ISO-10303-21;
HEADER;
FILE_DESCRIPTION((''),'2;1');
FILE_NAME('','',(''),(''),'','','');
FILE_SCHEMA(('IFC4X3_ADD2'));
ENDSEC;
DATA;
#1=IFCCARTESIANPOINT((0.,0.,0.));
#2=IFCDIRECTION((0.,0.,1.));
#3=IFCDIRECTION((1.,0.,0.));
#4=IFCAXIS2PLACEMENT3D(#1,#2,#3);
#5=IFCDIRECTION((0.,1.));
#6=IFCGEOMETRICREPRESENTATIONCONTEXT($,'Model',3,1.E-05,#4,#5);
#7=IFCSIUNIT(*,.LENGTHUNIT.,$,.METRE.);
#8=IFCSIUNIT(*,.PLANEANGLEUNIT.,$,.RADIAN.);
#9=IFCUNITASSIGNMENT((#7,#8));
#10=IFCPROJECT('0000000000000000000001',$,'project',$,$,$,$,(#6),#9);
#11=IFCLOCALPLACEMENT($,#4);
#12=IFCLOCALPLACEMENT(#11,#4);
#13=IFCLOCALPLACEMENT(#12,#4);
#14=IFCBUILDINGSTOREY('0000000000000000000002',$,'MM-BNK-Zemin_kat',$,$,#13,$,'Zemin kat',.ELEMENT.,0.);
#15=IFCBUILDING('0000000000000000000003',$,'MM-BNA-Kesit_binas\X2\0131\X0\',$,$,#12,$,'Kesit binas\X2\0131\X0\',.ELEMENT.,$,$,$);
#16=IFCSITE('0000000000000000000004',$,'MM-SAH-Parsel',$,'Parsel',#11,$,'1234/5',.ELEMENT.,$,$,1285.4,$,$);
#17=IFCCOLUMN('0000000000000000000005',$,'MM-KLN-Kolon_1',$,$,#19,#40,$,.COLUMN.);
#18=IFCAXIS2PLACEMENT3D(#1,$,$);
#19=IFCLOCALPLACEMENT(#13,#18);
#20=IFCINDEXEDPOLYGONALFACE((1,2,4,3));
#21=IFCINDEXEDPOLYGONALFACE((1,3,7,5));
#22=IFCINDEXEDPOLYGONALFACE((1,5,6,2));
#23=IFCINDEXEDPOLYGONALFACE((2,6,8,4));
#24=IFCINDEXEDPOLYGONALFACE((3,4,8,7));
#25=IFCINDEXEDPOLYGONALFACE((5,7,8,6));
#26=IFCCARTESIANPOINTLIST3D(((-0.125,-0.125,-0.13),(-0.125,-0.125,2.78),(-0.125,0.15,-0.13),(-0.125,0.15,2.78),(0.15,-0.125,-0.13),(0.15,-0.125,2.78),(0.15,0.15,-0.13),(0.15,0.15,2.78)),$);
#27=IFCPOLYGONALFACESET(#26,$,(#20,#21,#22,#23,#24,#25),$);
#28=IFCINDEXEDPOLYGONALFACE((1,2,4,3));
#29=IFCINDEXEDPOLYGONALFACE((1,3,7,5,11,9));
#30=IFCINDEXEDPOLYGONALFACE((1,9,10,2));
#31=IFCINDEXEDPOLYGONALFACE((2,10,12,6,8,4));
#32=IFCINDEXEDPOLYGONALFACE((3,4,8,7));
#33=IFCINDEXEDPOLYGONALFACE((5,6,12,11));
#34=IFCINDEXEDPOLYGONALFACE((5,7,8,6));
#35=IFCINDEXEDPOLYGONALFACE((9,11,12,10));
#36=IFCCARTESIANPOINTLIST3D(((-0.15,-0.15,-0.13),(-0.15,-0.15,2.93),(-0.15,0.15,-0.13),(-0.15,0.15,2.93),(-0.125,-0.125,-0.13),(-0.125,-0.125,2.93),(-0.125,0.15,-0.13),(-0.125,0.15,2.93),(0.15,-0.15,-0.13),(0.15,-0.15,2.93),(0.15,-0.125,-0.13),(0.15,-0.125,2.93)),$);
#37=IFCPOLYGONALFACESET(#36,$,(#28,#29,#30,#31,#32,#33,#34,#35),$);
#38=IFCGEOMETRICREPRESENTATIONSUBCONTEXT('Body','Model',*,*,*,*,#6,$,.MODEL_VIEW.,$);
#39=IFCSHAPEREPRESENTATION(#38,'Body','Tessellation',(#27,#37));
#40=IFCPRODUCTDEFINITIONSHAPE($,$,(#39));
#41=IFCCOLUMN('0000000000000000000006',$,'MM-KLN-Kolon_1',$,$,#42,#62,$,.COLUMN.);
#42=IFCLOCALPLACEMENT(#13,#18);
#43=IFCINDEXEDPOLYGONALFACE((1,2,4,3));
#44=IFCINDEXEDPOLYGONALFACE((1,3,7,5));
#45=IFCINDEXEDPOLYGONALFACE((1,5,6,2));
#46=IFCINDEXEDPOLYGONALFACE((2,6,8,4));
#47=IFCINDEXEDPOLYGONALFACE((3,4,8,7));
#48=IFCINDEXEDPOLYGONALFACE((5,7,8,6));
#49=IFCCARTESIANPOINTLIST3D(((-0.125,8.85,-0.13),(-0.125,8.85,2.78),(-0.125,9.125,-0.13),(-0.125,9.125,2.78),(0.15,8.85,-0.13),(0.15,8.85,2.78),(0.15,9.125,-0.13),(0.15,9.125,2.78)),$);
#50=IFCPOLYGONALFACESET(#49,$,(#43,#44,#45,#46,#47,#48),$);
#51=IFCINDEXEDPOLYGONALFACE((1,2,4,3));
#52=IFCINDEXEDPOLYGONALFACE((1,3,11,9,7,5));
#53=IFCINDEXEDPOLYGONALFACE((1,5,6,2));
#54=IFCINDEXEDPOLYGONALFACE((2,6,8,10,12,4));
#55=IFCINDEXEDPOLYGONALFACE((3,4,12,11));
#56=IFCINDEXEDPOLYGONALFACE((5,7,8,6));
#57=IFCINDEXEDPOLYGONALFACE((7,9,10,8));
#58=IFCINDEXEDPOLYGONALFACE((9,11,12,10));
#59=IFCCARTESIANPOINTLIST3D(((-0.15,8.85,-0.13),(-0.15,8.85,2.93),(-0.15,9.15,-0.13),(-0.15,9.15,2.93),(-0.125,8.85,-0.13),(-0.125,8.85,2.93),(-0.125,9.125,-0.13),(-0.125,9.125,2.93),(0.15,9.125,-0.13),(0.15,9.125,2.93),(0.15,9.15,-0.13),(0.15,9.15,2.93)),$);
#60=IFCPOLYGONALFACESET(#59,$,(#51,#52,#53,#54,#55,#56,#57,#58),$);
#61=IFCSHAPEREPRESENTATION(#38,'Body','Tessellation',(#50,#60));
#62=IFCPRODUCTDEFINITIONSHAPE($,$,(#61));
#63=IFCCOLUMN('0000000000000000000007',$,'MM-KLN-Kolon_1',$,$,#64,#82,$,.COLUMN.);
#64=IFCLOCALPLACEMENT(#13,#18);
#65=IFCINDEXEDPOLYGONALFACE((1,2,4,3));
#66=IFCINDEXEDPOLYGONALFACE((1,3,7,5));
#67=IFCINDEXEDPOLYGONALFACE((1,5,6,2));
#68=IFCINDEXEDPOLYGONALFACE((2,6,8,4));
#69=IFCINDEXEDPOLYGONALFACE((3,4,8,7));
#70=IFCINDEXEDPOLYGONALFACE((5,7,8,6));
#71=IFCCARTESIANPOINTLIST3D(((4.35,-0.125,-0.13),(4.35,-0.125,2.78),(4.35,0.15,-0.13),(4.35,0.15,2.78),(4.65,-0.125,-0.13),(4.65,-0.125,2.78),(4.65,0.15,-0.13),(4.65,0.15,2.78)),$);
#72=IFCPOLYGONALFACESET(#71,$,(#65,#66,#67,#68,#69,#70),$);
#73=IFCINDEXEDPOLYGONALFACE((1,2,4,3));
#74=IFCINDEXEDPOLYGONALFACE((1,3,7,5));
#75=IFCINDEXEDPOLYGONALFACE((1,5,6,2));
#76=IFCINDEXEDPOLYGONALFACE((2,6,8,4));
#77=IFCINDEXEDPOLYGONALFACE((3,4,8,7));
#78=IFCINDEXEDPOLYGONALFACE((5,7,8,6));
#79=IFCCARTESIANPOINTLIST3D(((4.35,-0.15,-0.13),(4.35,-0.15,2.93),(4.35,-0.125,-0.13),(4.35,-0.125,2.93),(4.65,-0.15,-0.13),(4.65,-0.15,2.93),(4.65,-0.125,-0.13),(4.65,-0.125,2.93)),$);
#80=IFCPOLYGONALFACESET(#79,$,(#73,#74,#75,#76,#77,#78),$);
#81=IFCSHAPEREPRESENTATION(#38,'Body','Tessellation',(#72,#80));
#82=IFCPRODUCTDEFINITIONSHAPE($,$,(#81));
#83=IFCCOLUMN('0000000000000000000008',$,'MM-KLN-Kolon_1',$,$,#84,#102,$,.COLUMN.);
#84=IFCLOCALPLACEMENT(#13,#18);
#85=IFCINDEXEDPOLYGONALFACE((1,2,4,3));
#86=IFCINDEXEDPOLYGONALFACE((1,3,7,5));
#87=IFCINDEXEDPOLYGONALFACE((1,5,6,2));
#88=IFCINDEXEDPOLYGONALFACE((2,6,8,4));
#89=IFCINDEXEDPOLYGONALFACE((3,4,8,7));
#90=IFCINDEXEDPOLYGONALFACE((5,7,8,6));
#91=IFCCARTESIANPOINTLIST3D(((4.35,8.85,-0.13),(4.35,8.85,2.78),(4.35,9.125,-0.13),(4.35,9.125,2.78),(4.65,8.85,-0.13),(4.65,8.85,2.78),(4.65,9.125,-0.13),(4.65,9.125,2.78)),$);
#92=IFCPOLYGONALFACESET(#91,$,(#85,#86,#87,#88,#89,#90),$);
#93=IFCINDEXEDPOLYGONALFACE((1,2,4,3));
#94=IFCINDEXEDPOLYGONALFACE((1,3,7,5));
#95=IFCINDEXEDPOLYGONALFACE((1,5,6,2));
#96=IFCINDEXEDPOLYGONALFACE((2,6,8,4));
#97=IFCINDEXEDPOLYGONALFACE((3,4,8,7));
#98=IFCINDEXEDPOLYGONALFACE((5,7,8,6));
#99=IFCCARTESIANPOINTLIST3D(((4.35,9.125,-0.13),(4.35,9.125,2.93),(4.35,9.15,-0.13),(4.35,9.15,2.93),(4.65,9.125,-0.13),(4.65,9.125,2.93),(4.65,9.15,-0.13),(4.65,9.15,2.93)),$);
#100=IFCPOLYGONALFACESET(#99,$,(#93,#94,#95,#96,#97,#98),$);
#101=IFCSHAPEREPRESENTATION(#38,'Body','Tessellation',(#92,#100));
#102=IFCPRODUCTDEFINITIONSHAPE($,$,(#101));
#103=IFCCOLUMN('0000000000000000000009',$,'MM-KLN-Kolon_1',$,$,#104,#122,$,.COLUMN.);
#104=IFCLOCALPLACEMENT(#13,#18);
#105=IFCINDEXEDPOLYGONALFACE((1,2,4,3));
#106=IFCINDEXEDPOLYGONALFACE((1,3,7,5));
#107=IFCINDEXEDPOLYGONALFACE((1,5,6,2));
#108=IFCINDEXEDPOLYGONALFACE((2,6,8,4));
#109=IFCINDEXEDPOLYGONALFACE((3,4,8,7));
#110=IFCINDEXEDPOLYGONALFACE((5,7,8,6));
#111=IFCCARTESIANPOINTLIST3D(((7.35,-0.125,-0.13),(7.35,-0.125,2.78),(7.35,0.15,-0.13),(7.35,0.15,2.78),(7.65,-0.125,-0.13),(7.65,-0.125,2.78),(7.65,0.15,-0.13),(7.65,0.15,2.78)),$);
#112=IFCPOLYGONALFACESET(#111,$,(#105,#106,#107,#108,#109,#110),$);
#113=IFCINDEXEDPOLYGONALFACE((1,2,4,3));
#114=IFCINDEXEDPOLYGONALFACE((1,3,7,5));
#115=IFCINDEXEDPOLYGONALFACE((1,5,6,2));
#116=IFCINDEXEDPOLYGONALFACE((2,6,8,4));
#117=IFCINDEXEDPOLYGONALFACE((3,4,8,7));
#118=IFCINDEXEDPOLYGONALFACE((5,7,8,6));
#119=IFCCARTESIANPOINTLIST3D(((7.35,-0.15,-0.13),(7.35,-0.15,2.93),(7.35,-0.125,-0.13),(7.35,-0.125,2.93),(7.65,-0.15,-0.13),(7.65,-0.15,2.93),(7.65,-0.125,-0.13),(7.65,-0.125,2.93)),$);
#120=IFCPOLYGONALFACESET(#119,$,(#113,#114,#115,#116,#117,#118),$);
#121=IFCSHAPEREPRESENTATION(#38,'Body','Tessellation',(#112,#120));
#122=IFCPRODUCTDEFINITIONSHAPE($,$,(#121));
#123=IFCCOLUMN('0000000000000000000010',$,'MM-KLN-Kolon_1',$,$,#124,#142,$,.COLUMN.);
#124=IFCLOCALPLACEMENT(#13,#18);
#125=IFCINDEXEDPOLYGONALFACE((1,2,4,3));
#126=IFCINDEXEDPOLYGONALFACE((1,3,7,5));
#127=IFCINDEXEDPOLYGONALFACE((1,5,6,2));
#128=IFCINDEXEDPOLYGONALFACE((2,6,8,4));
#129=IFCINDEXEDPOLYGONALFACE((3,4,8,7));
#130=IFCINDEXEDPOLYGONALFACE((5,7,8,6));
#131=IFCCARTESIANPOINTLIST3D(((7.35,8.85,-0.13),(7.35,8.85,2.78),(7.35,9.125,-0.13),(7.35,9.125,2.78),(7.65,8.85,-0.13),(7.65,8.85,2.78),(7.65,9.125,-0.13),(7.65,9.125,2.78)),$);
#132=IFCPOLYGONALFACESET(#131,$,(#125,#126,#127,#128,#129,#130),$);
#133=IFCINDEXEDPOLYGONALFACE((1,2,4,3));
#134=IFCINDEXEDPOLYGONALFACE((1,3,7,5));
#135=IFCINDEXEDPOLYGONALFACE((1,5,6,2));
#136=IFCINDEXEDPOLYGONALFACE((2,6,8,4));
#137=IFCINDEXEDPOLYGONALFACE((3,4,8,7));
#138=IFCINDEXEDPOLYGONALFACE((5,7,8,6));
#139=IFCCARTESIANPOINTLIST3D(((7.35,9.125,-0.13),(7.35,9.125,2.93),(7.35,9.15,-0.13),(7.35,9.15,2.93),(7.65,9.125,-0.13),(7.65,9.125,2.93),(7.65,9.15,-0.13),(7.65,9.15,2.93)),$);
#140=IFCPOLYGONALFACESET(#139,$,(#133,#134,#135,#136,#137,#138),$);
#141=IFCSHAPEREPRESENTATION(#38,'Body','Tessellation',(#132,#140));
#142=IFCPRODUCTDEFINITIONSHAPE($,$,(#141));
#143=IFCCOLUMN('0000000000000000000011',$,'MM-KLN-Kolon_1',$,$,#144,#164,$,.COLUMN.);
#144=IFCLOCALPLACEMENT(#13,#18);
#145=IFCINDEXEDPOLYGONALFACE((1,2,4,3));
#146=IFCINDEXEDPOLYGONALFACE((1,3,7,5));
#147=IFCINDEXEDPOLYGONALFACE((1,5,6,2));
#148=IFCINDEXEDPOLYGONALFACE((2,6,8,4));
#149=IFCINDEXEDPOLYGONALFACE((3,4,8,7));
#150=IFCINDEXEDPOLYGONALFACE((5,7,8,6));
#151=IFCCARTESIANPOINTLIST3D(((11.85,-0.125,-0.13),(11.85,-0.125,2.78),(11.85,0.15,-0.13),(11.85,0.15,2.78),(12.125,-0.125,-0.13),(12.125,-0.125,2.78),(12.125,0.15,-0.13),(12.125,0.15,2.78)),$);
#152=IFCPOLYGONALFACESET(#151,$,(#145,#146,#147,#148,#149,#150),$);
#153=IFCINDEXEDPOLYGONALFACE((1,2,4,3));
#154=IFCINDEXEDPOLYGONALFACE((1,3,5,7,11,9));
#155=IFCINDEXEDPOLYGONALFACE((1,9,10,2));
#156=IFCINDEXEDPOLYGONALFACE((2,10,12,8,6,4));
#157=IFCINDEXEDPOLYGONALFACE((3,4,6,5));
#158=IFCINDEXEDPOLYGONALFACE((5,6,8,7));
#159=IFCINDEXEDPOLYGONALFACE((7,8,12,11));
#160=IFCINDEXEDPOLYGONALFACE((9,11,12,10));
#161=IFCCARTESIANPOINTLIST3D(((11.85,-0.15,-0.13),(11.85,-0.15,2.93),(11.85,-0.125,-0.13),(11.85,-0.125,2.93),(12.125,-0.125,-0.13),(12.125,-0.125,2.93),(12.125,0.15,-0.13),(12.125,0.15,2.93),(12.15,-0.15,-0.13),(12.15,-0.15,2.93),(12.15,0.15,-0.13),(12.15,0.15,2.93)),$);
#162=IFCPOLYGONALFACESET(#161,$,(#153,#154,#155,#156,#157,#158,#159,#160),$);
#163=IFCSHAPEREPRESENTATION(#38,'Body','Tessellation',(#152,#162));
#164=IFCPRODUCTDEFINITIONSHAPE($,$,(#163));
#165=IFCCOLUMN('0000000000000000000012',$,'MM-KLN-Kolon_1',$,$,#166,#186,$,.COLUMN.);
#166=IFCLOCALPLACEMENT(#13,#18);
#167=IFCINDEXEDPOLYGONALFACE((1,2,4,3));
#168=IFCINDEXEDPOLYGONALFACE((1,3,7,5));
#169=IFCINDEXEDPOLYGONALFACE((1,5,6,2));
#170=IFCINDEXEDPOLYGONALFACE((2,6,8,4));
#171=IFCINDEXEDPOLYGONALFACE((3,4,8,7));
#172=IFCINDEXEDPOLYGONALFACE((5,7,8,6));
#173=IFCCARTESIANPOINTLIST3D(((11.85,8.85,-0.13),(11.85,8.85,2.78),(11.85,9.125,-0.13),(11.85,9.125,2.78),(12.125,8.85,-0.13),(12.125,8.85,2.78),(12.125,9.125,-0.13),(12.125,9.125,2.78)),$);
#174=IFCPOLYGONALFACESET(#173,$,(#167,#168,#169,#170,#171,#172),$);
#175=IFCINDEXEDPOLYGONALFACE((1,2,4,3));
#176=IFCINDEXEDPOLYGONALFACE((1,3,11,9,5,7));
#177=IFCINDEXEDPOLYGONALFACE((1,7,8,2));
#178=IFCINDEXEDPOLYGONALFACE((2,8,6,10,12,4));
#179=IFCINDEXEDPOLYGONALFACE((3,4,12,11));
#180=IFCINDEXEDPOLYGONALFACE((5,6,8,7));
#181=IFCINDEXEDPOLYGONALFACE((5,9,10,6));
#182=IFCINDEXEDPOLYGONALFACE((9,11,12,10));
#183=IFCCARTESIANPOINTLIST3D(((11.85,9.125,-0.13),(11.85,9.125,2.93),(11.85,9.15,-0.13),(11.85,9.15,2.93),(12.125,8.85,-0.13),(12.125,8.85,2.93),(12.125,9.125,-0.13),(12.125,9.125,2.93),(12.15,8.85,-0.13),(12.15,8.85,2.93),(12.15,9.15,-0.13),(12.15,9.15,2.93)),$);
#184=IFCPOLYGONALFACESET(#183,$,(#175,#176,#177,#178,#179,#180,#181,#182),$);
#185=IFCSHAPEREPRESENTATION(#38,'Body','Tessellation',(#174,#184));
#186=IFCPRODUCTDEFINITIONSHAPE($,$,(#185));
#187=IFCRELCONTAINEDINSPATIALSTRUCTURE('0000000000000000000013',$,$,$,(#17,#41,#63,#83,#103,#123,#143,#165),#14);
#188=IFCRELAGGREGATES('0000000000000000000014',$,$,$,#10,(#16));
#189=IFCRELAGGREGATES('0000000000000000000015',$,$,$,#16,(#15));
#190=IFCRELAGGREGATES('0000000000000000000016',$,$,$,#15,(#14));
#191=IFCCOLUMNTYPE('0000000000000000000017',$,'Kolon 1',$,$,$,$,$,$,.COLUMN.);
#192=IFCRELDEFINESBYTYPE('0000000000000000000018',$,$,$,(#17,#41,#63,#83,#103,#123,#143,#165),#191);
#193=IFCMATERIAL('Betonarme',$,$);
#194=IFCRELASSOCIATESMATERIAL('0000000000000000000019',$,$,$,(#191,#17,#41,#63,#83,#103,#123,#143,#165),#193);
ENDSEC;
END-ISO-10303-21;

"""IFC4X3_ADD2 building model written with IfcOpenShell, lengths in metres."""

from ifc_helpers import new_model, si_unit, direction, frame, origin_with_axes, place, context, subcontext, project, spatial, polyline, rectangle, outline, extrude, material, material_profile, profile_set, type_object, element, save


model = new_model("IFC4X3_ADD2")

# Units and contexts
model_context = context("Model", 3, precision=1e-05, world=origin_with_axes(), true_north=direction((0.0, 1.0)))
body_context = subcontext(model_context, "Body", "Model", "MODEL_VIEW")
ifc_project = project(units=[si_unit("LENGTHUNIT", "METRE"), si_unit("PLANEANGLEUNIT", "RADIAN")], contexts=[model_context])

# Site, building, storey
site_placement = place(None, origin_with_axes())
site = spatial("IfcSite", under=ifc_project, at=site_placement, Name="MM-SAH-Parsel", ObjectType="Parsel", LongName="1234/5", CompositionType="ELEMENT", RefElevation=1285.4)
building_placement = place(site_placement, origin_with_axes())
building = spatial("IfcBuilding", under=site, at=building_placement, Name="MM-BNA-Kesit_binası", LongName="Kesit binası", CompositionType="ELEMENT")
storey_placement = place(building_placement, origin_with_axes())
storey = spatial("IfcBuildingStorey", under=building, at=storey_placement, Name="MM-BNK-Zemin_kat", LongName="Zemin kat", CompositionType="ELEMENT", Elevation=0.0)

# Columns
ifc_material_1 = material(Name="Betonarme")
ifc_material_profile_1 = material_profile(ifc_material_1, rectangle(XDim=0.3, YDim=0.3), Category="LoadBearing")
ifc_profile_set_1 = profile_set([ifc_material_profile_1], Name="Kolon 1")
column_type = type_object("IfcColumnType", Name="Kolon 1", PredefinedType="COLUMN", material=ifc_profile_set_1)
column_1_placement = place(storey_placement, origin_with_axes())
element("IfcColumn", 1, at=column_1_placement, inside=storey, type_object=column_type, material=ifc_material_1, Name="MM-KLN-Kolon_1", PredefinedType="COLUMN", context=body_context, shape_type="SweptSolid", body=[
    extrude(outline(polyline([(0.15, -0.125), (0.15, 0.15), (-0.125, 0.15), (-0.125, -0.125), (0.15, -0.125)])), frame((0.0, 0.0, -0.13)), (0.0, 0.0, 1.0), 2.91),
    extrude(outline(polyline([(-0.15, -0.15), (0.15, -0.15), (0.15, -0.125), (-0.125, -0.125), (-0.125, 0.15), (-0.15, 0.15), (-0.15, -0.15)])), frame((0.0, 0.0, -0.13)), (0.0, 0.0, 1.0), 3.06),
])
column_2_placement = place(storey_placement, origin_with_axes())
element("IfcColumn", 2, at=column_2_placement, inside=storey, type_object=column_type, material=ifc_material_1, Name="MM-KLN-Kolon_1", PredefinedType="COLUMN", context=body_context, shape_type="SweptSolid", body=[
    extrude(outline(polyline([(-0.125, 8.85), (0.15, 8.85), (0.15, 9.125), (-0.125, 9.125), (-0.125, 8.85)])), frame((0.0, 0.0, -0.13)), (0.0, 0.0, 1.0), 2.91),
    extrude(outline(polyline([(-0.15, 8.85), (-0.125, 8.85), (-0.125, 9.125), (0.15, 9.125), (0.15, 9.15), (-0.15, 9.15), (-0.15, 8.85)])), frame((0.0, 0.0, -0.13)), (0.0, 0.0, 1.0), 3.06),
])
column_3_placement = place(storey_placement, origin_with_axes())
element("IfcColumn", 3, at=column_3_placement, inside=storey, type_object=column_type, material=ifc_material_1, Name="MM-KLN-Kolon_1", PredefinedType="COLUMN", context=body_context, shape_type="SweptSolid", body=[
    extrude(outline(polyline([(4.65, -0.125), (4.65, 0.15), (4.35, 0.15), (4.35, -0.125), (4.65, -0.125)])), frame((0.0, 0.0, -0.13)), (0.0, 0.0, 1.0), 2.91),
    extrude(outline(polyline([(4.35, -0.15), (4.65, -0.15), (4.65, -0.125), (4.35, -0.125), (4.35, -0.15)])), frame((0.0, 0.0, -0.13)), (0.0, 0.0, 1.0), 3.06),
])
column_4_placement = place(storey_placement, origin_with_axes())
element("IfcColumn", 4, at=column_4_placement, inside=storey, type_object=column_type, material=ifc_material_1, Name="MM-KLN-Kolon_1", PredefinedType="COLUMN", context=body_context, shape_type="SweptSolid", body=[
    extrude(outline(polyline([(4.35, 8.85), (4.65, 8.85), (4.65, 9.125), (4.35, 9.125), (4.35, 8.85)])), frame((0.0, 0.0, -0.13)), (0.0, 0.0, 1.0), 2.91),
    extrude(outline(polyline([(4.65, 9.125), (4.65, 9.15), (4.35, 9.15), (4.35, 9.125), (4.65, 9.125)])), frame((0.0, 0.0, -0.13)), (0.0, 0.0, 1.0), 3.06),
])
column_5_placement = place(storey_placement, origin_with_axes())
element("IfcColumn", 5, at=column_5_placement, inside=storey, type_object=column_type, material=ifc_material_1, Name="MM-KLN-Kolon_1", PredefinedType="COLUMN", context=body_context, shape_type="SweptSolid", body=[
    extrude(outline(polyline([(7.65, -0.125), (7.65, 0.15), (7.35, 0.15), (7.35, -0.125), (7.65, -0.125)])), frame((0.0, 0.0, -0.13)), (0.0, 0.0, 1.0), 2.91),
    extrude(outline(polyline([(7.35, -0.15), (7.65, -0.15), (7.65, -0.125), (7.35, -0.125), (7.35, -0.15)])), frame((0.0, 0.0, -0.13)), (0.0, 0.0, 1.0), 3.06),
])
column_6_placement = place(storey_placement, origin_with_axes())
element("IfcColumn", 6, at=column_6_placement, inside=storey, type_object=column_type, material=ifc_material_1, Name="MM-KLN-Kolon_1", PredefinedType="COLUMN", context=body_context, shape_type="SweptSolid", body=[
    extrude(outline(polyline([(7.35, 8.85), (7.65, 8.85), (7.65, 9.125), (7.35, 9.125), (7.35, 8.85)])), frame((0.0, 0.0, -0.13)), (0.0, 0.0, 1.0), 2.91),
    extrude(outline(polyline([(7.65, 9.125), (7.65, 9.15), (7.35, 9.15), (7.35, 9.125), (7.65, 9.125)])), frame((0.0, 0.0, -0.13)), (0.0, 0.0, 1.0), 3.06),
])
column_7_placement = place(storey_placement, origin_with_axes())
element("IfcColumn", 7, at=column_7_placement, inside=storey, type_object=column_type, material=ifc_material_1, Name="MM-KLN-Kolon_1", PredefinedType="COLUMN", context=body_context, shape_type="SweptSolid", body=[
    extrude(outline(polyline([(12.125, 0.15), (11.85, 0.15), (11.85, -0.125), (12.125, -0.125), (12.125, 0.15)])), frame((0.0, 0.0, -0.13)), (0.0, 0.0, 1.0), 2.91),
    extrude(outline(polyline([(11.85, -0.15), (12.15, -0.15), (12.15, 0.15), (12.125, 0.15), (12.125, -0.125), (11.85, -0.125), (11.85, -0.15)])), frame((0.0, 0.0, -0.13)), (0.0, 0.0, 1.0), 3.06),
])
column_8_placement = place(storey_placement, origin_with_axes())
element("IfcColumn", 8, at=column_8_placement, inside=storey, type_object=column_type, material=ifc_material_1, Name="MM-KLN-Kolon_1", PredefinedType="COLUMN", context=body_context, shape_type="SweptSolid", body=[
    extrude(outline(polyline([(11.85, 8.85), (12.125, 8.85), (12.125, 9.125), (11.85, 9.125), (11.85, 8.85)])), frame((0.0, 0.0, -0.13)), (0.0, 0.0, 1.0), 2.91),
    extrude(outline(polyline([(12.125, 8.85), (12.15, 8.85), (12.15, 9.15), (11.85, 9.15), (11.85, 9.125), (12.125, 9.125), (12.125, 8.85)])), frame((0.0, 0.0, -0.13)), (0.0, 0.0, 1.0), 3.06),
])

save(model, "model.ifc")
